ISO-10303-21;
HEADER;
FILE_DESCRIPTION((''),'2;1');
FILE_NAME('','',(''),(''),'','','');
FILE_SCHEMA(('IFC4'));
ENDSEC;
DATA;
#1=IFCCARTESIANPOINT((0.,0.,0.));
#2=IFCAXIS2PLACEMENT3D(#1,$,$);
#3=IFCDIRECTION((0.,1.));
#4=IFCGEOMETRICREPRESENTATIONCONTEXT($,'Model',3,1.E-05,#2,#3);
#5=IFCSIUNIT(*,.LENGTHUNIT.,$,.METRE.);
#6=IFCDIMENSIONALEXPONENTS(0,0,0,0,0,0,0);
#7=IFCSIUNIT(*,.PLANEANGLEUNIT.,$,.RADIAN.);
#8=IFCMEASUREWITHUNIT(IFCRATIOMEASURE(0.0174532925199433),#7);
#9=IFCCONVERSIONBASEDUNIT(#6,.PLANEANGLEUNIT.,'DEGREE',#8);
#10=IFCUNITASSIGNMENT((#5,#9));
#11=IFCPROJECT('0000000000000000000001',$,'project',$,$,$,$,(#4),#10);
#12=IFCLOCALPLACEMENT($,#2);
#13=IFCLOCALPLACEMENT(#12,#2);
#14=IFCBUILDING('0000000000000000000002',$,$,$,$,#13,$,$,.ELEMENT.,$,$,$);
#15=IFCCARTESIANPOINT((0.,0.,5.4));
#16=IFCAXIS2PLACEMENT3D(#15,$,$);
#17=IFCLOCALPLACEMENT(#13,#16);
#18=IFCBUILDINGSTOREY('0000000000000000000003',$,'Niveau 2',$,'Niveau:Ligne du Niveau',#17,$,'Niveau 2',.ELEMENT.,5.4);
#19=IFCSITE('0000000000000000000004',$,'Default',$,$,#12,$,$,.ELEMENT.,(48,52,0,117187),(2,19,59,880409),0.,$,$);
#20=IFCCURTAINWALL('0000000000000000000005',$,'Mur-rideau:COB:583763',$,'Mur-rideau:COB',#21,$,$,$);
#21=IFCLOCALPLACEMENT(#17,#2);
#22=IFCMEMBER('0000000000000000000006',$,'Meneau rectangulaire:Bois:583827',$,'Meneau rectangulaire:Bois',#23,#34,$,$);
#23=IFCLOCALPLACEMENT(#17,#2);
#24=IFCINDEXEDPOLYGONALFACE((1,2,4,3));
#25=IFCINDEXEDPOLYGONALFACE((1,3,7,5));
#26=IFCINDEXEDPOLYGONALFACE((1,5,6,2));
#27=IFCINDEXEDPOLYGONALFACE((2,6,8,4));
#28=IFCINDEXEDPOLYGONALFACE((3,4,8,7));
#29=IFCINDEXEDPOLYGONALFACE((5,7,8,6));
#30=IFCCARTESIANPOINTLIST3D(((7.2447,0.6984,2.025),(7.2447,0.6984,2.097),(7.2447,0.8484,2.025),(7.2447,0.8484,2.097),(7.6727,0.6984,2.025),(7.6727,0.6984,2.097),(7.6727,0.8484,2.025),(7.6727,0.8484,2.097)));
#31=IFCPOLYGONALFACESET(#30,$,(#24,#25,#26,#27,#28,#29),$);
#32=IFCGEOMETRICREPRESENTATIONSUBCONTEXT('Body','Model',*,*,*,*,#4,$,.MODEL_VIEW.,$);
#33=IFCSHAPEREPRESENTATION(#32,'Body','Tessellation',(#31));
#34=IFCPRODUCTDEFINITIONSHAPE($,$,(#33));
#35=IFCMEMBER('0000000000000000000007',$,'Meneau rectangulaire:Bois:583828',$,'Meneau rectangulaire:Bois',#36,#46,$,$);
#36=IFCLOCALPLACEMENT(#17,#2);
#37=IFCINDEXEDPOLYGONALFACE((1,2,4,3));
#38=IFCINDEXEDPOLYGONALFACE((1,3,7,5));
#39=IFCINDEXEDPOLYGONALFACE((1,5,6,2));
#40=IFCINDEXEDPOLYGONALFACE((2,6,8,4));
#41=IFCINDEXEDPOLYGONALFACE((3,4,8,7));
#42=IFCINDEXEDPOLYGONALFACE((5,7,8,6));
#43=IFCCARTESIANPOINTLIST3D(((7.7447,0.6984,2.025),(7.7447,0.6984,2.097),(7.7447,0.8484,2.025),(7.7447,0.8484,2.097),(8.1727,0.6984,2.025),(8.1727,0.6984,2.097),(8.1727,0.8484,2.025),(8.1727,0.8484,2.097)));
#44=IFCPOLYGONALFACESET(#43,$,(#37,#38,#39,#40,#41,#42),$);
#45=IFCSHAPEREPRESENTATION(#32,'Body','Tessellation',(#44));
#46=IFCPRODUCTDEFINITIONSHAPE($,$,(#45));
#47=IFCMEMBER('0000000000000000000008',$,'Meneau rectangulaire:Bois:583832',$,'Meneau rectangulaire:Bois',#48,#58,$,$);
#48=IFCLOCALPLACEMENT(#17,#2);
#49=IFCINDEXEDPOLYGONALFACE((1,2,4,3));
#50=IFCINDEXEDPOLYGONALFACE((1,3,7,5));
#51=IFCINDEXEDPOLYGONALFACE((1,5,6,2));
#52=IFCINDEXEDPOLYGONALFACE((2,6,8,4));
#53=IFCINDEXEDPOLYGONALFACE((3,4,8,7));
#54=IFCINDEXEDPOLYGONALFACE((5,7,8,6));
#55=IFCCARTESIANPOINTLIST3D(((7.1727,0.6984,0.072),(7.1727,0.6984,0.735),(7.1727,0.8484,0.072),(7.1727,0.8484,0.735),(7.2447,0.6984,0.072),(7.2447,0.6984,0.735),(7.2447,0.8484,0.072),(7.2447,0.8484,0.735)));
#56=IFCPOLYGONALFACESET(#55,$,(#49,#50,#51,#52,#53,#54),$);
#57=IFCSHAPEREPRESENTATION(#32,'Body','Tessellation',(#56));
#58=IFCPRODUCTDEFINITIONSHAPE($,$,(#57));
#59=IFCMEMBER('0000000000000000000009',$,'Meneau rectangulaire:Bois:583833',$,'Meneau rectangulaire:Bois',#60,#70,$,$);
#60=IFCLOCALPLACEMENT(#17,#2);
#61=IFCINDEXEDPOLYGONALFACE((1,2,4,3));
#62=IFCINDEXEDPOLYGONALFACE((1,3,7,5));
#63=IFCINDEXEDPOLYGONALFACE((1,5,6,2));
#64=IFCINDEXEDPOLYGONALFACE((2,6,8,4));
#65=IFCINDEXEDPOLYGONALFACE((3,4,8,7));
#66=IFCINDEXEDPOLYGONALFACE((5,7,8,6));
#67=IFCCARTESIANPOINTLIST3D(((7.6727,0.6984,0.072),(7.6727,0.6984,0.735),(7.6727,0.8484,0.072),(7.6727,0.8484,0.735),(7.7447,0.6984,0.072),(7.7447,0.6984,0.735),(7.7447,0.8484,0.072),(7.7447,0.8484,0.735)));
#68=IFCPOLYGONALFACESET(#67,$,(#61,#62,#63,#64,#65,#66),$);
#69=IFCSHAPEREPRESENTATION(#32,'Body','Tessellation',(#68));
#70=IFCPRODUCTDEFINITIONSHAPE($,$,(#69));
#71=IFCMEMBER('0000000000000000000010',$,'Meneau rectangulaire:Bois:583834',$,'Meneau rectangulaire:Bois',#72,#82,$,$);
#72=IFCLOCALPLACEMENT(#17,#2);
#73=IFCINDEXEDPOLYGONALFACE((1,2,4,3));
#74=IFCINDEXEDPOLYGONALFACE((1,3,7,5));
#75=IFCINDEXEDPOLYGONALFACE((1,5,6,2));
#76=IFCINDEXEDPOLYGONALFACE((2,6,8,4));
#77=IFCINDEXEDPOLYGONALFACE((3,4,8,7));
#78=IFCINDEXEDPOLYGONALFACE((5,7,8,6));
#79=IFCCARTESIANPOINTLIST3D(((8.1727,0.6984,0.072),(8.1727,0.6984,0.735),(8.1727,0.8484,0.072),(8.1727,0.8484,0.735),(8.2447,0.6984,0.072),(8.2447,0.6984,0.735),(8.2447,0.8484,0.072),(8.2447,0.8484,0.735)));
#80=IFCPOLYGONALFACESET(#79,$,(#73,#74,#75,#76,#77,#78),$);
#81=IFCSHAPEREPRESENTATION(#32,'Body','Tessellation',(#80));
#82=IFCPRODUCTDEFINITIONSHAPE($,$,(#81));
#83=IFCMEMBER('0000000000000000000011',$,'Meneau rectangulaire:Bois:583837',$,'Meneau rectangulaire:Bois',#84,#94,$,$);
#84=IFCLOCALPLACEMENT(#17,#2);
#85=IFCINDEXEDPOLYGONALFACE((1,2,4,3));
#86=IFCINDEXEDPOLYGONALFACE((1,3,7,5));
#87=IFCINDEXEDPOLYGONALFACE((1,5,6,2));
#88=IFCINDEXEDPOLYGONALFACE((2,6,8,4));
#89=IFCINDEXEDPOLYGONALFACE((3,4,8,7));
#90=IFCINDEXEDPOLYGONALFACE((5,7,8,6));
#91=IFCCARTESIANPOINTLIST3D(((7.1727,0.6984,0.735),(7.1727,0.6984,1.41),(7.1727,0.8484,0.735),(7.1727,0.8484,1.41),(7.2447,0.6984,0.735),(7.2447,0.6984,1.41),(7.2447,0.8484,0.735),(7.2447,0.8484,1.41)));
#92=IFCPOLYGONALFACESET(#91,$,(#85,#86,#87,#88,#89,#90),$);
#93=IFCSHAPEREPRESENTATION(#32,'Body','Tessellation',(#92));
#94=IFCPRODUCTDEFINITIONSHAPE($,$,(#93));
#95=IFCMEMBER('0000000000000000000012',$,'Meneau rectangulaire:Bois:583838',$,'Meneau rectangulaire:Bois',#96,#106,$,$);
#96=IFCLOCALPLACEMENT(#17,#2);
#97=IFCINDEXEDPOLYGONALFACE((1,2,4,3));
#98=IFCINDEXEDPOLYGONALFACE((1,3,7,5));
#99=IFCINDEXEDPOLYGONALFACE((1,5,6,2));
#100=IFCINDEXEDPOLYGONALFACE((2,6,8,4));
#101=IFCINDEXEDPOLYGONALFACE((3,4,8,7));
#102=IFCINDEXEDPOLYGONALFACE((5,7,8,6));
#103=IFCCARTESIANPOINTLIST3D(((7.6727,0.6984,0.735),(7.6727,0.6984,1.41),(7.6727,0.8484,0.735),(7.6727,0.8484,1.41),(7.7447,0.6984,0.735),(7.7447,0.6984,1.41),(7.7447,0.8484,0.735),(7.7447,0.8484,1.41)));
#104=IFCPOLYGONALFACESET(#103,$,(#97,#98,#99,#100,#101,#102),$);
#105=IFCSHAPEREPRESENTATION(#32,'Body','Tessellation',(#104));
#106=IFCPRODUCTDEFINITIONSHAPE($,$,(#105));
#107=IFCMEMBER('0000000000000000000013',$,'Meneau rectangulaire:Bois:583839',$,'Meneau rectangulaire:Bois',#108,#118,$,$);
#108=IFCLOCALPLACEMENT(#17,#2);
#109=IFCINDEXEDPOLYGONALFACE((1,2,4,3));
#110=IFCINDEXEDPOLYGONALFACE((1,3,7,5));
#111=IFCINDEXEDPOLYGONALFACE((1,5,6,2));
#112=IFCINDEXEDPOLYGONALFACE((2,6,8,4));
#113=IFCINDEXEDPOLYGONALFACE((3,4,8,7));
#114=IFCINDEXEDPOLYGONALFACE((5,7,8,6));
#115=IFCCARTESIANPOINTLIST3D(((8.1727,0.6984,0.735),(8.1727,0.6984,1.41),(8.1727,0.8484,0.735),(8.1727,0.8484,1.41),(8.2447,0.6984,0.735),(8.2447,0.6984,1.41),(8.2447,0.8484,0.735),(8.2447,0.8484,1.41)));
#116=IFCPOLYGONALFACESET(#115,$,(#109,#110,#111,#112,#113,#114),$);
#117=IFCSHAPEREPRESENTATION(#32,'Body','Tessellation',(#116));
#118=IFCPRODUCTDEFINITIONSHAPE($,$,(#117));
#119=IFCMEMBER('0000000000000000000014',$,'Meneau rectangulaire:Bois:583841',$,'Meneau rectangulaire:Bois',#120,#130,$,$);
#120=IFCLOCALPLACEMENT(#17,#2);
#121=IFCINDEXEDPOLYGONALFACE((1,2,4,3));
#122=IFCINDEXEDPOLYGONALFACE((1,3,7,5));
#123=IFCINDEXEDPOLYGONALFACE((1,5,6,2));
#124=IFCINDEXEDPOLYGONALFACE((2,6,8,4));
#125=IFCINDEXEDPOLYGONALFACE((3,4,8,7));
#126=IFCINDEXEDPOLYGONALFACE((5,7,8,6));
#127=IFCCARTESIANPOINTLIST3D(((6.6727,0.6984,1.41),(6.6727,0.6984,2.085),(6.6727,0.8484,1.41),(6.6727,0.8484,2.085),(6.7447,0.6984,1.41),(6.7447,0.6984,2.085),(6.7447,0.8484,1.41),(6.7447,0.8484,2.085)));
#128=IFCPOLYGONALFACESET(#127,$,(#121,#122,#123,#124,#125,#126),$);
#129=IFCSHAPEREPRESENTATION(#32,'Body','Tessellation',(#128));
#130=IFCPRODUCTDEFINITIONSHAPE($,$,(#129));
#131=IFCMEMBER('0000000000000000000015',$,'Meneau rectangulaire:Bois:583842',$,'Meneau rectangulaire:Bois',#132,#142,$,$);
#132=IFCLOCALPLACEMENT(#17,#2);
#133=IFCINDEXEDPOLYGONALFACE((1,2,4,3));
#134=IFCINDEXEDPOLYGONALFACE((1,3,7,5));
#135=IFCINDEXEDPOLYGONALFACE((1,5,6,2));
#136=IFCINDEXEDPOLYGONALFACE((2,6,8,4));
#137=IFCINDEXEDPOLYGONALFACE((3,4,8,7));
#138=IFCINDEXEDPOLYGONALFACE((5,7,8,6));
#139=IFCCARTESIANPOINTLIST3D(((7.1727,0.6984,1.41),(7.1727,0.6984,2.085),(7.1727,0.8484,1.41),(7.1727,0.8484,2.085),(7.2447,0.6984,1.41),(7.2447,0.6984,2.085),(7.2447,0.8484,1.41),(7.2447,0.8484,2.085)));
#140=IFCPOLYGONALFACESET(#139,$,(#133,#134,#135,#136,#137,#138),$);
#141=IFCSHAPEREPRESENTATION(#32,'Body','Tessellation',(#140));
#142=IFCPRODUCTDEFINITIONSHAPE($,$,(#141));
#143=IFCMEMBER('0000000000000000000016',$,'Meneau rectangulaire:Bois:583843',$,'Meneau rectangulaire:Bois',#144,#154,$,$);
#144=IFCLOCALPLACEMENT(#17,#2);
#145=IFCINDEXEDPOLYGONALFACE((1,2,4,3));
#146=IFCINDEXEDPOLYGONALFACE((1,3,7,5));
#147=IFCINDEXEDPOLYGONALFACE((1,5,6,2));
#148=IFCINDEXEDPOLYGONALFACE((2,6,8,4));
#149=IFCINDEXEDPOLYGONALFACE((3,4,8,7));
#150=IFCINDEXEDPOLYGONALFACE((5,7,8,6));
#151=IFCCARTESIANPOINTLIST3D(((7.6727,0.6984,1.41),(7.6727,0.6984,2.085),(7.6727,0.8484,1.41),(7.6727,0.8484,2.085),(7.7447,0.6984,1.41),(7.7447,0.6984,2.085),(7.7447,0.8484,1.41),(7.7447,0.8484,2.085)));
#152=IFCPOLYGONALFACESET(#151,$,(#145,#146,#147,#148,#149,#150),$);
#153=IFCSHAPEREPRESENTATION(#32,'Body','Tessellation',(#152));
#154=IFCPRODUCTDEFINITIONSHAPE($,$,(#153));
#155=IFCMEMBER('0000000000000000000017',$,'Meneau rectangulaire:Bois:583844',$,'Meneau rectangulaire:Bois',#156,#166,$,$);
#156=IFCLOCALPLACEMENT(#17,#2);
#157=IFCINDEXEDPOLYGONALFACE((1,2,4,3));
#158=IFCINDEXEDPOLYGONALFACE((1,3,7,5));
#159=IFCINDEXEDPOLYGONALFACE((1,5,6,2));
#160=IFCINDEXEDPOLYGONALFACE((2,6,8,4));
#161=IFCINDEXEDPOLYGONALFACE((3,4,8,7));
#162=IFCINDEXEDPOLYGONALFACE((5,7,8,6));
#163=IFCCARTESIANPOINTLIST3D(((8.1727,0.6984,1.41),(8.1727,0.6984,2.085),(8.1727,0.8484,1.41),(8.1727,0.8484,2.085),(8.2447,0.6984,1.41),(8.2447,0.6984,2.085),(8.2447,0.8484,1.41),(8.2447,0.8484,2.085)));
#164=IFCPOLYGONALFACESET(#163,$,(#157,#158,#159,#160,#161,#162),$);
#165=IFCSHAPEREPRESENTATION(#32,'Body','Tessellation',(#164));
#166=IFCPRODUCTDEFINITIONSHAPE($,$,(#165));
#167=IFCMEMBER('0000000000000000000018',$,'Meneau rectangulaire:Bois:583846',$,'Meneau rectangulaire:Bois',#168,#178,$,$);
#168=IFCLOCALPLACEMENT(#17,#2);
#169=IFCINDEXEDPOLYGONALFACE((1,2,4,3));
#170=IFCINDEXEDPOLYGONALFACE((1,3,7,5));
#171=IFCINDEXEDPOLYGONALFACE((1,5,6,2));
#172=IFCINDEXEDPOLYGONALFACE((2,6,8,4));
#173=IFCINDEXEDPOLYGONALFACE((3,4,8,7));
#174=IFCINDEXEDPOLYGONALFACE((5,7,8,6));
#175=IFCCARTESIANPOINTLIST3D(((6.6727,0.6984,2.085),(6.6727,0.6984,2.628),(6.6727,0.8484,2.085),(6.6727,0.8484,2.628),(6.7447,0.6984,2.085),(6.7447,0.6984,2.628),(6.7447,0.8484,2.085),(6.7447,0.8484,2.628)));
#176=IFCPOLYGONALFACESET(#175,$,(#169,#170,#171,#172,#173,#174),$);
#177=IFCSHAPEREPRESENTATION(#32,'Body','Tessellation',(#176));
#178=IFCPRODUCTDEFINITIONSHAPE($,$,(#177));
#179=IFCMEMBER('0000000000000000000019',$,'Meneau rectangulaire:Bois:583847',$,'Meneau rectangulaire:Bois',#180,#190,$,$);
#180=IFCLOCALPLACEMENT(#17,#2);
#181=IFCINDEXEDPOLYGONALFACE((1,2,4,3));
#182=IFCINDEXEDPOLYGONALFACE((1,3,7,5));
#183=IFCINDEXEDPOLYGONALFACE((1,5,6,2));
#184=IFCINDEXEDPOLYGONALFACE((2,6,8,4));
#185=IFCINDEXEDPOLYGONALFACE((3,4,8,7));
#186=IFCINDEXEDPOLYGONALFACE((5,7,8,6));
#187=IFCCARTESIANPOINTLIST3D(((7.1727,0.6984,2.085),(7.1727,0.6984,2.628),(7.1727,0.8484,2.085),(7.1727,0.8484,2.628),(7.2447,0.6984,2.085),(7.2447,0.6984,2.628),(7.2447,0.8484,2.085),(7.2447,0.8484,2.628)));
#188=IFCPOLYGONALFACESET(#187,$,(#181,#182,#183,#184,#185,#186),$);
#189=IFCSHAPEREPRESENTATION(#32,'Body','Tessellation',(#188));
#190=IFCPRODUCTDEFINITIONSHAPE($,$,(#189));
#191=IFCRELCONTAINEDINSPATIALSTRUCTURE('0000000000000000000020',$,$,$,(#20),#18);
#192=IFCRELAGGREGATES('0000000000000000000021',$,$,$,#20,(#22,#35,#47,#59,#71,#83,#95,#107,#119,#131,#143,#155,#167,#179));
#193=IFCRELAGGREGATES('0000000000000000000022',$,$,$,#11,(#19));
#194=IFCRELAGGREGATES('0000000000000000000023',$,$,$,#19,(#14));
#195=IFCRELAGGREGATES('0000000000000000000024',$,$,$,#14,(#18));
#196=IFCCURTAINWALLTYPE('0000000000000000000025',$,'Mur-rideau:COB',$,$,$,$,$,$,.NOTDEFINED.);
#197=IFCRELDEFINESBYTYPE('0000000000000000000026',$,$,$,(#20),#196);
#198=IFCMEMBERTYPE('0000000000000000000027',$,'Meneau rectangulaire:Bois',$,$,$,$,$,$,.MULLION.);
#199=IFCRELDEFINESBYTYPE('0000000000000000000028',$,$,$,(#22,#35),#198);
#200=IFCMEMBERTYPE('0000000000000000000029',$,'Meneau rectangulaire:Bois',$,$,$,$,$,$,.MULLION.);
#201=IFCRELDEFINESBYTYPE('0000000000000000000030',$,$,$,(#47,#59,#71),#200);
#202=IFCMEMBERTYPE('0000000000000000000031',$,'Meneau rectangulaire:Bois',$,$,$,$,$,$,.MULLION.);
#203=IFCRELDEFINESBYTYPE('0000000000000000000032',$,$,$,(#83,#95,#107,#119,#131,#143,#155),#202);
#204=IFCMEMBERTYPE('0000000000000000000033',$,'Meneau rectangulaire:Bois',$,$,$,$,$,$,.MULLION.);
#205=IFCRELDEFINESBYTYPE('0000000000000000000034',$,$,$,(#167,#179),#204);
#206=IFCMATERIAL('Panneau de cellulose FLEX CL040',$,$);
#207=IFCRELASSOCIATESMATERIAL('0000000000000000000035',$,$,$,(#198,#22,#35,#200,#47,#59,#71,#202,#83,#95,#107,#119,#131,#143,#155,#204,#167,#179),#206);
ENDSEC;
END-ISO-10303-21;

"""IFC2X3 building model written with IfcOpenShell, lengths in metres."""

from ifc_helpers import new_model, entity, si_unit, converted_unit, direction, frame, origin, origin_2d_with_axis, place, context, subcontext, project, spatial, rectangle, extrude, source, transform, mapped, material, type_object, type_shapes, element, aggregate, save


model = new_model("IFC2X3")

# Units and contexts
model_context = context("Model", 3, precision=1e-05, world=origin(), true_north=direction((0.0, 1.0)))
body_context = subcontext(model_context, "Body", "Model", "MODEL_VIEW")
ifc_project = project(units=[si_unit("LENGTHUNIT", "METRE"), converted_unit("PLANEANGLEUNIT", "DEGREE", entity("IfcRatioMeasure", 0.0174532925199433), si_unit("PLANEANGLEUNIT", "RADIAN"), dimensions=[0, 0, 0, 0, 0, 0, 0])], contexts=[model_context])

# Site, building, storey
site_placement = place(None, origin())
site = spatial("IfcSite", under=ifc_project, at=site_placement, Name="Default", CompositionType="ELEMENT", RefLatitude=(48, 52, 0, 117187), RefLongitude=(2, 19, 59, 880409), RefElevation=0.0)
building_placement = place(site_placement, origin())
building = spatial("IfcBuilding", under=site, at=building_placement, CompositionType="ELEMENT")
storey_placement = place(building_placement, frame((0.0, 0.0, 5.4)))
storey = spatial("IfcBuildingStorey", under=building, at=storey_placement, Name="Niveau 2", ObjectType="Niveau:Ligne du Niveau", LongName="Niveau 2", CompositionType="ELEMENT", Elevation=5.4)

# Curtain wall, members
curtain_wall_type_1 = type_object("IfcCurtainWallType", Name="Mur-rideau:COB", PredefinedType="NOTDEFINED")
curtain_wall_1_placement = place(storey_placement, frame((0.0, 0.0, -5.4)))
curtain_wall_1 = element("IfcCurtainWall", 1, at=curtain_wall_1_placement, inside=storey, type_object=curtain_wall_type_1, Name="Mur-rideau:COB:583763", ObjectType="Mur-rideau:COB")
ifc_material_1 = material(Name="Panneau de cellulose FLEX CL040")
member_type_1 = type_object("IfcMemberType", Name="Meneau rectangulaire:Bois", PredefinedType="MULLION", material=ifc_material_1)
shared_shape_1 = source(origin(), body_context, "Body", "SweptSolid", [
    extrude(rectangle(XDim=0.15, YDim=0.072, at=origin_2d_with_axis()), frame((-0.024, 0.0, -0.428), z_axis=(0.0, 0.0, 1.0), x_axis=(0.0, -1.0, 0.0)), (0.0, 0.0, 1.0), 0.428),
])
type_shapes(member_type_1, [shared_shape_1])
member_1_placement = place(storey_placement, frame((7.6727, 0.7734, 2.085), z_axis=(1.0, 0.0, 0.0), x_axis=(0.0, 0.0, 1.0)))
member_1 = element("IfcMember", 2, at=member_1_placement, type_object=member_type_1, material=ifc_material_1, Name="Meneau rectangulaire:Bois:583827", ObjectType="Meneau rectangulaire:Bois", context=body_context, shape_type="MappedRepresentation", body=[
    mapped(shared_shape_1, transform((0.0, 0.0, 0.0), scale=1.0)),
])
member_2_placement = place(storey_placement, frame((8.1727, 0.7734, 2.085), z_axis=(1.0, 0.0, 0.0), x_axis=(0.0, 0.0, 1.0)))
member_2 = element("IfcMember", 3, at=member_2_placement, type_object=member_type_1, material=ifc_material_1, Name="Meneau rectangulaire:Bois:583828", ObjectType="Meneau rectangulaire:Bois", context=body_context, shape_type="MappedRepresentation", body=[
    mapped(shared_shape_1, transform((0.0, 0.0, 0.0), scale=1.0)),
])
member_type_2 = type_object("IfcMemberType", Name="Meneau rectangulaire:Bois", PredefinedType="MULLION", material=ifc_material_1)
shared_shape_2 = source(origin(), body_context, "Body", "SweptSolid", [
    extrude(rectangle(XDim=0.15, YDim=0.072, at=origin_2d_with_axis()), frame((-0.024, 0.0, -0.663), z_axis=(0.0, 0.0, 1.0), x_axis=(0.0, -1.0, 0.0)), (0.0, 0.0, 1.0), 0.663),
])
type_shapes(member_type_2, [shared_shape_2])
member_3_placement = place(storey_placement, frame((7.2327, 0.7734, 0.072), z_axis=(0.0, 0.0, -1.0), x_axis=(1.0, 0.0, 0.0)))
member_3 = element("IfcMember", 4, at=member_3_placement, type_object=member_type_2, material=ifc_material_1, Name="Meneau rectangulaire:Bois:583832", ObjectType="Meneau rectangulaire:Bois", context=body_context, shape_type="MappedRepresentation", body=[
    mapped(shared_shape_2, transform((0.0, 0.0, 0.0), scale=1.0)),
])
member_4_placement = place(storey_placement, frame((7.7327, 0.7734, 0.072), z_axis=(0.0, 0.0, -1.0), x_axis=(1.0, 0.0, 0.0)))
member_4 = element("IfcMember", 5, at=member_4_placement, type_object=member_type_2, material=ifc_material_1, Name="Meneau rectangulaire:Bois:583833", ObjectType="Meneau rectangulaire:Bois", context=body_context, shape_type="MappedRepresentation", body=[
    mapped(shared_shape_2, transform((0.0, 0.0, 0.0), scale=1.0)),
])
member_5_placement = place(storey_placement, frame((8.2327, 0.7734, 0.072), z_axis=(0.0, 0.0, -1.0), x_axis=(1.0, 0.0, 0.0)))
member_5 = element("IfcMember", 6, at=member_5_placement, type_object=member_type_2, material=ifc_material_1, Name="Meneau rectangulaire:Bois:583834", ObjectType="Meneau rectangulaire:Bois", context=body_context, shape_type="MappedRepresentation", body=[
    mapped(shared_shape_2, transform((0.0, 0.0, 0.0), scale=1.0)),
])
member_type_3 = type_object("IfcMemberType", Name="Meneau rectangulaire:Bois", PredefinedType="MULLION", material=ifc_material_1)
shared_shape_3 = source(origin(), body_context, "Body", "SweptSolid", [
    extrude(rectangle(XDim=0.15, YDim=0.072, at=origin_2d_with_axis()), frame((-0.024, 0.0, -0.675), z_axis=(0.0, 0.0, 1.0), x_axis=(0.0, -1.0, 0.0)), (0.0, 0.0, 1.0), 0.675),
])
type_shapes(member_type_3, [shared_shape_3])
member_6_placement = place(storey_placement, frame((7.2327, 0.7734, 0.735), z_axis=(0.0, 0.0, -1.0), x_axis=(1.0, 0.0, 0.0)))
member_6 = element("IfcMember", 7, at=member_6_placement, type_object=member_type_3, material=ifc_material_1, Name="Meneau rectangulaire:Bois:583837", ObjectType="Meneau rectangulaire:Bois", context=body_context, shape_type="MappedRepresentation", body=[
    mapped(shared_shape_3, transform((0.0, 0.0, 0.0), scale=1.0)),
])
member_7_placement = place(storey_placement, frame((7.7327, 0.7734, 0.735), z_axis=(0.0, 0.0, -1.0), x_axis=(1.0, 0.0, 0.0)))
member_7 = element("IfcMember", 8, at=member_7_placement, type_object=member_type_3, material=ifc_material_1, Name="Meneau rectangulaire:Bois:583838", ObjectType="Meneau rectangulaire:Bois", context=body_context, shape_type="MappedRepresentation", body=[
    mapped(shared_shape_3, transform((0.0, 0.0, 0.0), scale=1.0)),
])
member_8_placement = place(storey_placement, frame((8.2327, 0.7734, 0.735), z_axis=(0.0, 0.0, -1.0), x_axis=(1.0, 0.0, 0.0)))
member_8 = element("IfcMember", 9, at=member_8_placement, type_object=member_type_3, material=ifc_material_1, Name="Meneau rectangulaire:Bois:583839", ObjectType="Meneau rectangulaire:Bois", context=body_context, shape_type="MappedRepresentation", body=[
    mapped(shared_shape_3, transform((0.0, 0.0, 0.0), scale=1.0)),
])
member_9_placement = place(storey_placement, frame((6.7327, 0.7734, 1.41), z_axis=(0.0, 0.0, -1.0), x_axis=(1.0, 0.0, 0.0)))
member_9 = element("IfcMember", 10, at=member_9_placement, type_object=member_type_3, material=ifc_material_1, Name="Meneau rectangulaire:Bois:583841", ObjectType="Meneau rectangulaire:Bois", context=body_context, shape_type="MappedRepresentation", body=[
    mapped(shared_shape_3, transform((0.0, 0.0, 0.0), scale=1.0)),
])
member_10_placement = place(storey_placement, frame((7.2327, 0.7734, 1.41), z_axis=(0.0, 0.0, -1.0), x_axis=(1.0, 0.0, 0.0)))
member_10 = element("IfcMember", 11, at=member_10_placement, type_object=member_type_3, material=ifc_material_1, Name="Meneau rectangulaire:Bois:583842", ObjectType="Meneau rectangulaire:Bois", context=body_context, shape_type="MappedRepresentation", body=[
    mapped(shared_shape_3, transform((0.0, 0.0, 0.0), scale=1.0)),
])
member_11_placement = place(storey_placement, frame((7.7327, 0.7734, 1.41), z_axis=(0.0, 0.0, -1.0), x_axis=(1.0, 0.0, 0.0)))
member_11 = element("IfcMember", 12, at=member_11_placement, type_object=member_type_3, material=ifc_material_1, Name="Meneau rectangulaire:Bois:583843", ObjectType="Meneau rectangulaire:Bois", context=body_context, shape_type="MappedRepresentation", body=[
    mapped(shared_shape_3, transform((0.0, 0.0, 0.0), scale=1.0)),
])
member_12_placement = place(storey_placement, frame((8.2327, 0.7734, 1.41), z_axis=(0.0, 0.0, -1.0), x_axis=(1.0, 0.0, 0.0)))
member_12 = element("IfcMember", 13, at=member_12_placement, type_object=member_type_3, material=ifc_material_1, Name="Meneau rectangulaire:Bois:583844", ObjectType="Meneau rectangulaire:Bois", context=body_context, shape_type="MappedRepresentation", body=[
    mapped(shared_shape_3, transform((0.0, 0.0, 0.0), scale=1.0)),
])
member_type_4 = type_object("IfcMemberType", Name="Meneau rectangulaire:Bois", PredefinedType="MULLION", material=ifc_material_1)
shared_shape_4 = source(origin(), body_context, "Body", "SweptSolid", [
    extrude(rectangle(XDim=0.15, YDim=0.072, at=origin_2d_with_axis()), frame((-0.024, 0.0, -0.543), z_axis=(0.0, 0.0, 1.0), x_axis=(0.0, -1.0, 0.0)), (0.0, 0.0, 1.0), 0.543),
])
type_shapes(member_type_4, [shared_shape_4])
member_13_placement = place(storey_placement, frame((6.7327, 0.7734, 2.085), z_axis=(0.0, 0.0, -1.0), x_axis=(1.0, 0.0, 0.0)))
member_13 = element("IfcMember", 14, at=member_13_placement, type_object=member_type_4, material=ifc_material_1, Name="Meneau rectangulaire:Bois:583846", ObjectType="Meneau rectangulaire:Bois", context=body_context, shape_type="MappedRepresentation", body=[
    mapped(shared_shape_4, transform((0.0, 0.0, 0.0), scale=1.0)),
])
member_14_placement = place(storey_placement, frame((7.2327, 0.7734, 2.085), z_axis=(0.0, 0.0, -1.0), x_axis=(1.0, 0.0, 0.0)))
member_14 = element("IfcMember", 15, at=member_14_placement, type_object=member_type_4, material=ifc_material_1, Name="Meneau rectangulaire:Bois:583847", ObjectType="Meneau rectangulaire:Bois", context=body_context, shape_type="MappedRepresentation", body=[
    mapped(shared_shape_4, transform((0.0, 0.0, 0.0), scale=1.0)),
])
aggregate(curtain_wall_1, [member_1, member_2, member_3, member_4, member_5, member_6, member_7, member_8, member_9, member_10, member_11, member_12, member_13, member_14])

save(model, "model.ifc")
